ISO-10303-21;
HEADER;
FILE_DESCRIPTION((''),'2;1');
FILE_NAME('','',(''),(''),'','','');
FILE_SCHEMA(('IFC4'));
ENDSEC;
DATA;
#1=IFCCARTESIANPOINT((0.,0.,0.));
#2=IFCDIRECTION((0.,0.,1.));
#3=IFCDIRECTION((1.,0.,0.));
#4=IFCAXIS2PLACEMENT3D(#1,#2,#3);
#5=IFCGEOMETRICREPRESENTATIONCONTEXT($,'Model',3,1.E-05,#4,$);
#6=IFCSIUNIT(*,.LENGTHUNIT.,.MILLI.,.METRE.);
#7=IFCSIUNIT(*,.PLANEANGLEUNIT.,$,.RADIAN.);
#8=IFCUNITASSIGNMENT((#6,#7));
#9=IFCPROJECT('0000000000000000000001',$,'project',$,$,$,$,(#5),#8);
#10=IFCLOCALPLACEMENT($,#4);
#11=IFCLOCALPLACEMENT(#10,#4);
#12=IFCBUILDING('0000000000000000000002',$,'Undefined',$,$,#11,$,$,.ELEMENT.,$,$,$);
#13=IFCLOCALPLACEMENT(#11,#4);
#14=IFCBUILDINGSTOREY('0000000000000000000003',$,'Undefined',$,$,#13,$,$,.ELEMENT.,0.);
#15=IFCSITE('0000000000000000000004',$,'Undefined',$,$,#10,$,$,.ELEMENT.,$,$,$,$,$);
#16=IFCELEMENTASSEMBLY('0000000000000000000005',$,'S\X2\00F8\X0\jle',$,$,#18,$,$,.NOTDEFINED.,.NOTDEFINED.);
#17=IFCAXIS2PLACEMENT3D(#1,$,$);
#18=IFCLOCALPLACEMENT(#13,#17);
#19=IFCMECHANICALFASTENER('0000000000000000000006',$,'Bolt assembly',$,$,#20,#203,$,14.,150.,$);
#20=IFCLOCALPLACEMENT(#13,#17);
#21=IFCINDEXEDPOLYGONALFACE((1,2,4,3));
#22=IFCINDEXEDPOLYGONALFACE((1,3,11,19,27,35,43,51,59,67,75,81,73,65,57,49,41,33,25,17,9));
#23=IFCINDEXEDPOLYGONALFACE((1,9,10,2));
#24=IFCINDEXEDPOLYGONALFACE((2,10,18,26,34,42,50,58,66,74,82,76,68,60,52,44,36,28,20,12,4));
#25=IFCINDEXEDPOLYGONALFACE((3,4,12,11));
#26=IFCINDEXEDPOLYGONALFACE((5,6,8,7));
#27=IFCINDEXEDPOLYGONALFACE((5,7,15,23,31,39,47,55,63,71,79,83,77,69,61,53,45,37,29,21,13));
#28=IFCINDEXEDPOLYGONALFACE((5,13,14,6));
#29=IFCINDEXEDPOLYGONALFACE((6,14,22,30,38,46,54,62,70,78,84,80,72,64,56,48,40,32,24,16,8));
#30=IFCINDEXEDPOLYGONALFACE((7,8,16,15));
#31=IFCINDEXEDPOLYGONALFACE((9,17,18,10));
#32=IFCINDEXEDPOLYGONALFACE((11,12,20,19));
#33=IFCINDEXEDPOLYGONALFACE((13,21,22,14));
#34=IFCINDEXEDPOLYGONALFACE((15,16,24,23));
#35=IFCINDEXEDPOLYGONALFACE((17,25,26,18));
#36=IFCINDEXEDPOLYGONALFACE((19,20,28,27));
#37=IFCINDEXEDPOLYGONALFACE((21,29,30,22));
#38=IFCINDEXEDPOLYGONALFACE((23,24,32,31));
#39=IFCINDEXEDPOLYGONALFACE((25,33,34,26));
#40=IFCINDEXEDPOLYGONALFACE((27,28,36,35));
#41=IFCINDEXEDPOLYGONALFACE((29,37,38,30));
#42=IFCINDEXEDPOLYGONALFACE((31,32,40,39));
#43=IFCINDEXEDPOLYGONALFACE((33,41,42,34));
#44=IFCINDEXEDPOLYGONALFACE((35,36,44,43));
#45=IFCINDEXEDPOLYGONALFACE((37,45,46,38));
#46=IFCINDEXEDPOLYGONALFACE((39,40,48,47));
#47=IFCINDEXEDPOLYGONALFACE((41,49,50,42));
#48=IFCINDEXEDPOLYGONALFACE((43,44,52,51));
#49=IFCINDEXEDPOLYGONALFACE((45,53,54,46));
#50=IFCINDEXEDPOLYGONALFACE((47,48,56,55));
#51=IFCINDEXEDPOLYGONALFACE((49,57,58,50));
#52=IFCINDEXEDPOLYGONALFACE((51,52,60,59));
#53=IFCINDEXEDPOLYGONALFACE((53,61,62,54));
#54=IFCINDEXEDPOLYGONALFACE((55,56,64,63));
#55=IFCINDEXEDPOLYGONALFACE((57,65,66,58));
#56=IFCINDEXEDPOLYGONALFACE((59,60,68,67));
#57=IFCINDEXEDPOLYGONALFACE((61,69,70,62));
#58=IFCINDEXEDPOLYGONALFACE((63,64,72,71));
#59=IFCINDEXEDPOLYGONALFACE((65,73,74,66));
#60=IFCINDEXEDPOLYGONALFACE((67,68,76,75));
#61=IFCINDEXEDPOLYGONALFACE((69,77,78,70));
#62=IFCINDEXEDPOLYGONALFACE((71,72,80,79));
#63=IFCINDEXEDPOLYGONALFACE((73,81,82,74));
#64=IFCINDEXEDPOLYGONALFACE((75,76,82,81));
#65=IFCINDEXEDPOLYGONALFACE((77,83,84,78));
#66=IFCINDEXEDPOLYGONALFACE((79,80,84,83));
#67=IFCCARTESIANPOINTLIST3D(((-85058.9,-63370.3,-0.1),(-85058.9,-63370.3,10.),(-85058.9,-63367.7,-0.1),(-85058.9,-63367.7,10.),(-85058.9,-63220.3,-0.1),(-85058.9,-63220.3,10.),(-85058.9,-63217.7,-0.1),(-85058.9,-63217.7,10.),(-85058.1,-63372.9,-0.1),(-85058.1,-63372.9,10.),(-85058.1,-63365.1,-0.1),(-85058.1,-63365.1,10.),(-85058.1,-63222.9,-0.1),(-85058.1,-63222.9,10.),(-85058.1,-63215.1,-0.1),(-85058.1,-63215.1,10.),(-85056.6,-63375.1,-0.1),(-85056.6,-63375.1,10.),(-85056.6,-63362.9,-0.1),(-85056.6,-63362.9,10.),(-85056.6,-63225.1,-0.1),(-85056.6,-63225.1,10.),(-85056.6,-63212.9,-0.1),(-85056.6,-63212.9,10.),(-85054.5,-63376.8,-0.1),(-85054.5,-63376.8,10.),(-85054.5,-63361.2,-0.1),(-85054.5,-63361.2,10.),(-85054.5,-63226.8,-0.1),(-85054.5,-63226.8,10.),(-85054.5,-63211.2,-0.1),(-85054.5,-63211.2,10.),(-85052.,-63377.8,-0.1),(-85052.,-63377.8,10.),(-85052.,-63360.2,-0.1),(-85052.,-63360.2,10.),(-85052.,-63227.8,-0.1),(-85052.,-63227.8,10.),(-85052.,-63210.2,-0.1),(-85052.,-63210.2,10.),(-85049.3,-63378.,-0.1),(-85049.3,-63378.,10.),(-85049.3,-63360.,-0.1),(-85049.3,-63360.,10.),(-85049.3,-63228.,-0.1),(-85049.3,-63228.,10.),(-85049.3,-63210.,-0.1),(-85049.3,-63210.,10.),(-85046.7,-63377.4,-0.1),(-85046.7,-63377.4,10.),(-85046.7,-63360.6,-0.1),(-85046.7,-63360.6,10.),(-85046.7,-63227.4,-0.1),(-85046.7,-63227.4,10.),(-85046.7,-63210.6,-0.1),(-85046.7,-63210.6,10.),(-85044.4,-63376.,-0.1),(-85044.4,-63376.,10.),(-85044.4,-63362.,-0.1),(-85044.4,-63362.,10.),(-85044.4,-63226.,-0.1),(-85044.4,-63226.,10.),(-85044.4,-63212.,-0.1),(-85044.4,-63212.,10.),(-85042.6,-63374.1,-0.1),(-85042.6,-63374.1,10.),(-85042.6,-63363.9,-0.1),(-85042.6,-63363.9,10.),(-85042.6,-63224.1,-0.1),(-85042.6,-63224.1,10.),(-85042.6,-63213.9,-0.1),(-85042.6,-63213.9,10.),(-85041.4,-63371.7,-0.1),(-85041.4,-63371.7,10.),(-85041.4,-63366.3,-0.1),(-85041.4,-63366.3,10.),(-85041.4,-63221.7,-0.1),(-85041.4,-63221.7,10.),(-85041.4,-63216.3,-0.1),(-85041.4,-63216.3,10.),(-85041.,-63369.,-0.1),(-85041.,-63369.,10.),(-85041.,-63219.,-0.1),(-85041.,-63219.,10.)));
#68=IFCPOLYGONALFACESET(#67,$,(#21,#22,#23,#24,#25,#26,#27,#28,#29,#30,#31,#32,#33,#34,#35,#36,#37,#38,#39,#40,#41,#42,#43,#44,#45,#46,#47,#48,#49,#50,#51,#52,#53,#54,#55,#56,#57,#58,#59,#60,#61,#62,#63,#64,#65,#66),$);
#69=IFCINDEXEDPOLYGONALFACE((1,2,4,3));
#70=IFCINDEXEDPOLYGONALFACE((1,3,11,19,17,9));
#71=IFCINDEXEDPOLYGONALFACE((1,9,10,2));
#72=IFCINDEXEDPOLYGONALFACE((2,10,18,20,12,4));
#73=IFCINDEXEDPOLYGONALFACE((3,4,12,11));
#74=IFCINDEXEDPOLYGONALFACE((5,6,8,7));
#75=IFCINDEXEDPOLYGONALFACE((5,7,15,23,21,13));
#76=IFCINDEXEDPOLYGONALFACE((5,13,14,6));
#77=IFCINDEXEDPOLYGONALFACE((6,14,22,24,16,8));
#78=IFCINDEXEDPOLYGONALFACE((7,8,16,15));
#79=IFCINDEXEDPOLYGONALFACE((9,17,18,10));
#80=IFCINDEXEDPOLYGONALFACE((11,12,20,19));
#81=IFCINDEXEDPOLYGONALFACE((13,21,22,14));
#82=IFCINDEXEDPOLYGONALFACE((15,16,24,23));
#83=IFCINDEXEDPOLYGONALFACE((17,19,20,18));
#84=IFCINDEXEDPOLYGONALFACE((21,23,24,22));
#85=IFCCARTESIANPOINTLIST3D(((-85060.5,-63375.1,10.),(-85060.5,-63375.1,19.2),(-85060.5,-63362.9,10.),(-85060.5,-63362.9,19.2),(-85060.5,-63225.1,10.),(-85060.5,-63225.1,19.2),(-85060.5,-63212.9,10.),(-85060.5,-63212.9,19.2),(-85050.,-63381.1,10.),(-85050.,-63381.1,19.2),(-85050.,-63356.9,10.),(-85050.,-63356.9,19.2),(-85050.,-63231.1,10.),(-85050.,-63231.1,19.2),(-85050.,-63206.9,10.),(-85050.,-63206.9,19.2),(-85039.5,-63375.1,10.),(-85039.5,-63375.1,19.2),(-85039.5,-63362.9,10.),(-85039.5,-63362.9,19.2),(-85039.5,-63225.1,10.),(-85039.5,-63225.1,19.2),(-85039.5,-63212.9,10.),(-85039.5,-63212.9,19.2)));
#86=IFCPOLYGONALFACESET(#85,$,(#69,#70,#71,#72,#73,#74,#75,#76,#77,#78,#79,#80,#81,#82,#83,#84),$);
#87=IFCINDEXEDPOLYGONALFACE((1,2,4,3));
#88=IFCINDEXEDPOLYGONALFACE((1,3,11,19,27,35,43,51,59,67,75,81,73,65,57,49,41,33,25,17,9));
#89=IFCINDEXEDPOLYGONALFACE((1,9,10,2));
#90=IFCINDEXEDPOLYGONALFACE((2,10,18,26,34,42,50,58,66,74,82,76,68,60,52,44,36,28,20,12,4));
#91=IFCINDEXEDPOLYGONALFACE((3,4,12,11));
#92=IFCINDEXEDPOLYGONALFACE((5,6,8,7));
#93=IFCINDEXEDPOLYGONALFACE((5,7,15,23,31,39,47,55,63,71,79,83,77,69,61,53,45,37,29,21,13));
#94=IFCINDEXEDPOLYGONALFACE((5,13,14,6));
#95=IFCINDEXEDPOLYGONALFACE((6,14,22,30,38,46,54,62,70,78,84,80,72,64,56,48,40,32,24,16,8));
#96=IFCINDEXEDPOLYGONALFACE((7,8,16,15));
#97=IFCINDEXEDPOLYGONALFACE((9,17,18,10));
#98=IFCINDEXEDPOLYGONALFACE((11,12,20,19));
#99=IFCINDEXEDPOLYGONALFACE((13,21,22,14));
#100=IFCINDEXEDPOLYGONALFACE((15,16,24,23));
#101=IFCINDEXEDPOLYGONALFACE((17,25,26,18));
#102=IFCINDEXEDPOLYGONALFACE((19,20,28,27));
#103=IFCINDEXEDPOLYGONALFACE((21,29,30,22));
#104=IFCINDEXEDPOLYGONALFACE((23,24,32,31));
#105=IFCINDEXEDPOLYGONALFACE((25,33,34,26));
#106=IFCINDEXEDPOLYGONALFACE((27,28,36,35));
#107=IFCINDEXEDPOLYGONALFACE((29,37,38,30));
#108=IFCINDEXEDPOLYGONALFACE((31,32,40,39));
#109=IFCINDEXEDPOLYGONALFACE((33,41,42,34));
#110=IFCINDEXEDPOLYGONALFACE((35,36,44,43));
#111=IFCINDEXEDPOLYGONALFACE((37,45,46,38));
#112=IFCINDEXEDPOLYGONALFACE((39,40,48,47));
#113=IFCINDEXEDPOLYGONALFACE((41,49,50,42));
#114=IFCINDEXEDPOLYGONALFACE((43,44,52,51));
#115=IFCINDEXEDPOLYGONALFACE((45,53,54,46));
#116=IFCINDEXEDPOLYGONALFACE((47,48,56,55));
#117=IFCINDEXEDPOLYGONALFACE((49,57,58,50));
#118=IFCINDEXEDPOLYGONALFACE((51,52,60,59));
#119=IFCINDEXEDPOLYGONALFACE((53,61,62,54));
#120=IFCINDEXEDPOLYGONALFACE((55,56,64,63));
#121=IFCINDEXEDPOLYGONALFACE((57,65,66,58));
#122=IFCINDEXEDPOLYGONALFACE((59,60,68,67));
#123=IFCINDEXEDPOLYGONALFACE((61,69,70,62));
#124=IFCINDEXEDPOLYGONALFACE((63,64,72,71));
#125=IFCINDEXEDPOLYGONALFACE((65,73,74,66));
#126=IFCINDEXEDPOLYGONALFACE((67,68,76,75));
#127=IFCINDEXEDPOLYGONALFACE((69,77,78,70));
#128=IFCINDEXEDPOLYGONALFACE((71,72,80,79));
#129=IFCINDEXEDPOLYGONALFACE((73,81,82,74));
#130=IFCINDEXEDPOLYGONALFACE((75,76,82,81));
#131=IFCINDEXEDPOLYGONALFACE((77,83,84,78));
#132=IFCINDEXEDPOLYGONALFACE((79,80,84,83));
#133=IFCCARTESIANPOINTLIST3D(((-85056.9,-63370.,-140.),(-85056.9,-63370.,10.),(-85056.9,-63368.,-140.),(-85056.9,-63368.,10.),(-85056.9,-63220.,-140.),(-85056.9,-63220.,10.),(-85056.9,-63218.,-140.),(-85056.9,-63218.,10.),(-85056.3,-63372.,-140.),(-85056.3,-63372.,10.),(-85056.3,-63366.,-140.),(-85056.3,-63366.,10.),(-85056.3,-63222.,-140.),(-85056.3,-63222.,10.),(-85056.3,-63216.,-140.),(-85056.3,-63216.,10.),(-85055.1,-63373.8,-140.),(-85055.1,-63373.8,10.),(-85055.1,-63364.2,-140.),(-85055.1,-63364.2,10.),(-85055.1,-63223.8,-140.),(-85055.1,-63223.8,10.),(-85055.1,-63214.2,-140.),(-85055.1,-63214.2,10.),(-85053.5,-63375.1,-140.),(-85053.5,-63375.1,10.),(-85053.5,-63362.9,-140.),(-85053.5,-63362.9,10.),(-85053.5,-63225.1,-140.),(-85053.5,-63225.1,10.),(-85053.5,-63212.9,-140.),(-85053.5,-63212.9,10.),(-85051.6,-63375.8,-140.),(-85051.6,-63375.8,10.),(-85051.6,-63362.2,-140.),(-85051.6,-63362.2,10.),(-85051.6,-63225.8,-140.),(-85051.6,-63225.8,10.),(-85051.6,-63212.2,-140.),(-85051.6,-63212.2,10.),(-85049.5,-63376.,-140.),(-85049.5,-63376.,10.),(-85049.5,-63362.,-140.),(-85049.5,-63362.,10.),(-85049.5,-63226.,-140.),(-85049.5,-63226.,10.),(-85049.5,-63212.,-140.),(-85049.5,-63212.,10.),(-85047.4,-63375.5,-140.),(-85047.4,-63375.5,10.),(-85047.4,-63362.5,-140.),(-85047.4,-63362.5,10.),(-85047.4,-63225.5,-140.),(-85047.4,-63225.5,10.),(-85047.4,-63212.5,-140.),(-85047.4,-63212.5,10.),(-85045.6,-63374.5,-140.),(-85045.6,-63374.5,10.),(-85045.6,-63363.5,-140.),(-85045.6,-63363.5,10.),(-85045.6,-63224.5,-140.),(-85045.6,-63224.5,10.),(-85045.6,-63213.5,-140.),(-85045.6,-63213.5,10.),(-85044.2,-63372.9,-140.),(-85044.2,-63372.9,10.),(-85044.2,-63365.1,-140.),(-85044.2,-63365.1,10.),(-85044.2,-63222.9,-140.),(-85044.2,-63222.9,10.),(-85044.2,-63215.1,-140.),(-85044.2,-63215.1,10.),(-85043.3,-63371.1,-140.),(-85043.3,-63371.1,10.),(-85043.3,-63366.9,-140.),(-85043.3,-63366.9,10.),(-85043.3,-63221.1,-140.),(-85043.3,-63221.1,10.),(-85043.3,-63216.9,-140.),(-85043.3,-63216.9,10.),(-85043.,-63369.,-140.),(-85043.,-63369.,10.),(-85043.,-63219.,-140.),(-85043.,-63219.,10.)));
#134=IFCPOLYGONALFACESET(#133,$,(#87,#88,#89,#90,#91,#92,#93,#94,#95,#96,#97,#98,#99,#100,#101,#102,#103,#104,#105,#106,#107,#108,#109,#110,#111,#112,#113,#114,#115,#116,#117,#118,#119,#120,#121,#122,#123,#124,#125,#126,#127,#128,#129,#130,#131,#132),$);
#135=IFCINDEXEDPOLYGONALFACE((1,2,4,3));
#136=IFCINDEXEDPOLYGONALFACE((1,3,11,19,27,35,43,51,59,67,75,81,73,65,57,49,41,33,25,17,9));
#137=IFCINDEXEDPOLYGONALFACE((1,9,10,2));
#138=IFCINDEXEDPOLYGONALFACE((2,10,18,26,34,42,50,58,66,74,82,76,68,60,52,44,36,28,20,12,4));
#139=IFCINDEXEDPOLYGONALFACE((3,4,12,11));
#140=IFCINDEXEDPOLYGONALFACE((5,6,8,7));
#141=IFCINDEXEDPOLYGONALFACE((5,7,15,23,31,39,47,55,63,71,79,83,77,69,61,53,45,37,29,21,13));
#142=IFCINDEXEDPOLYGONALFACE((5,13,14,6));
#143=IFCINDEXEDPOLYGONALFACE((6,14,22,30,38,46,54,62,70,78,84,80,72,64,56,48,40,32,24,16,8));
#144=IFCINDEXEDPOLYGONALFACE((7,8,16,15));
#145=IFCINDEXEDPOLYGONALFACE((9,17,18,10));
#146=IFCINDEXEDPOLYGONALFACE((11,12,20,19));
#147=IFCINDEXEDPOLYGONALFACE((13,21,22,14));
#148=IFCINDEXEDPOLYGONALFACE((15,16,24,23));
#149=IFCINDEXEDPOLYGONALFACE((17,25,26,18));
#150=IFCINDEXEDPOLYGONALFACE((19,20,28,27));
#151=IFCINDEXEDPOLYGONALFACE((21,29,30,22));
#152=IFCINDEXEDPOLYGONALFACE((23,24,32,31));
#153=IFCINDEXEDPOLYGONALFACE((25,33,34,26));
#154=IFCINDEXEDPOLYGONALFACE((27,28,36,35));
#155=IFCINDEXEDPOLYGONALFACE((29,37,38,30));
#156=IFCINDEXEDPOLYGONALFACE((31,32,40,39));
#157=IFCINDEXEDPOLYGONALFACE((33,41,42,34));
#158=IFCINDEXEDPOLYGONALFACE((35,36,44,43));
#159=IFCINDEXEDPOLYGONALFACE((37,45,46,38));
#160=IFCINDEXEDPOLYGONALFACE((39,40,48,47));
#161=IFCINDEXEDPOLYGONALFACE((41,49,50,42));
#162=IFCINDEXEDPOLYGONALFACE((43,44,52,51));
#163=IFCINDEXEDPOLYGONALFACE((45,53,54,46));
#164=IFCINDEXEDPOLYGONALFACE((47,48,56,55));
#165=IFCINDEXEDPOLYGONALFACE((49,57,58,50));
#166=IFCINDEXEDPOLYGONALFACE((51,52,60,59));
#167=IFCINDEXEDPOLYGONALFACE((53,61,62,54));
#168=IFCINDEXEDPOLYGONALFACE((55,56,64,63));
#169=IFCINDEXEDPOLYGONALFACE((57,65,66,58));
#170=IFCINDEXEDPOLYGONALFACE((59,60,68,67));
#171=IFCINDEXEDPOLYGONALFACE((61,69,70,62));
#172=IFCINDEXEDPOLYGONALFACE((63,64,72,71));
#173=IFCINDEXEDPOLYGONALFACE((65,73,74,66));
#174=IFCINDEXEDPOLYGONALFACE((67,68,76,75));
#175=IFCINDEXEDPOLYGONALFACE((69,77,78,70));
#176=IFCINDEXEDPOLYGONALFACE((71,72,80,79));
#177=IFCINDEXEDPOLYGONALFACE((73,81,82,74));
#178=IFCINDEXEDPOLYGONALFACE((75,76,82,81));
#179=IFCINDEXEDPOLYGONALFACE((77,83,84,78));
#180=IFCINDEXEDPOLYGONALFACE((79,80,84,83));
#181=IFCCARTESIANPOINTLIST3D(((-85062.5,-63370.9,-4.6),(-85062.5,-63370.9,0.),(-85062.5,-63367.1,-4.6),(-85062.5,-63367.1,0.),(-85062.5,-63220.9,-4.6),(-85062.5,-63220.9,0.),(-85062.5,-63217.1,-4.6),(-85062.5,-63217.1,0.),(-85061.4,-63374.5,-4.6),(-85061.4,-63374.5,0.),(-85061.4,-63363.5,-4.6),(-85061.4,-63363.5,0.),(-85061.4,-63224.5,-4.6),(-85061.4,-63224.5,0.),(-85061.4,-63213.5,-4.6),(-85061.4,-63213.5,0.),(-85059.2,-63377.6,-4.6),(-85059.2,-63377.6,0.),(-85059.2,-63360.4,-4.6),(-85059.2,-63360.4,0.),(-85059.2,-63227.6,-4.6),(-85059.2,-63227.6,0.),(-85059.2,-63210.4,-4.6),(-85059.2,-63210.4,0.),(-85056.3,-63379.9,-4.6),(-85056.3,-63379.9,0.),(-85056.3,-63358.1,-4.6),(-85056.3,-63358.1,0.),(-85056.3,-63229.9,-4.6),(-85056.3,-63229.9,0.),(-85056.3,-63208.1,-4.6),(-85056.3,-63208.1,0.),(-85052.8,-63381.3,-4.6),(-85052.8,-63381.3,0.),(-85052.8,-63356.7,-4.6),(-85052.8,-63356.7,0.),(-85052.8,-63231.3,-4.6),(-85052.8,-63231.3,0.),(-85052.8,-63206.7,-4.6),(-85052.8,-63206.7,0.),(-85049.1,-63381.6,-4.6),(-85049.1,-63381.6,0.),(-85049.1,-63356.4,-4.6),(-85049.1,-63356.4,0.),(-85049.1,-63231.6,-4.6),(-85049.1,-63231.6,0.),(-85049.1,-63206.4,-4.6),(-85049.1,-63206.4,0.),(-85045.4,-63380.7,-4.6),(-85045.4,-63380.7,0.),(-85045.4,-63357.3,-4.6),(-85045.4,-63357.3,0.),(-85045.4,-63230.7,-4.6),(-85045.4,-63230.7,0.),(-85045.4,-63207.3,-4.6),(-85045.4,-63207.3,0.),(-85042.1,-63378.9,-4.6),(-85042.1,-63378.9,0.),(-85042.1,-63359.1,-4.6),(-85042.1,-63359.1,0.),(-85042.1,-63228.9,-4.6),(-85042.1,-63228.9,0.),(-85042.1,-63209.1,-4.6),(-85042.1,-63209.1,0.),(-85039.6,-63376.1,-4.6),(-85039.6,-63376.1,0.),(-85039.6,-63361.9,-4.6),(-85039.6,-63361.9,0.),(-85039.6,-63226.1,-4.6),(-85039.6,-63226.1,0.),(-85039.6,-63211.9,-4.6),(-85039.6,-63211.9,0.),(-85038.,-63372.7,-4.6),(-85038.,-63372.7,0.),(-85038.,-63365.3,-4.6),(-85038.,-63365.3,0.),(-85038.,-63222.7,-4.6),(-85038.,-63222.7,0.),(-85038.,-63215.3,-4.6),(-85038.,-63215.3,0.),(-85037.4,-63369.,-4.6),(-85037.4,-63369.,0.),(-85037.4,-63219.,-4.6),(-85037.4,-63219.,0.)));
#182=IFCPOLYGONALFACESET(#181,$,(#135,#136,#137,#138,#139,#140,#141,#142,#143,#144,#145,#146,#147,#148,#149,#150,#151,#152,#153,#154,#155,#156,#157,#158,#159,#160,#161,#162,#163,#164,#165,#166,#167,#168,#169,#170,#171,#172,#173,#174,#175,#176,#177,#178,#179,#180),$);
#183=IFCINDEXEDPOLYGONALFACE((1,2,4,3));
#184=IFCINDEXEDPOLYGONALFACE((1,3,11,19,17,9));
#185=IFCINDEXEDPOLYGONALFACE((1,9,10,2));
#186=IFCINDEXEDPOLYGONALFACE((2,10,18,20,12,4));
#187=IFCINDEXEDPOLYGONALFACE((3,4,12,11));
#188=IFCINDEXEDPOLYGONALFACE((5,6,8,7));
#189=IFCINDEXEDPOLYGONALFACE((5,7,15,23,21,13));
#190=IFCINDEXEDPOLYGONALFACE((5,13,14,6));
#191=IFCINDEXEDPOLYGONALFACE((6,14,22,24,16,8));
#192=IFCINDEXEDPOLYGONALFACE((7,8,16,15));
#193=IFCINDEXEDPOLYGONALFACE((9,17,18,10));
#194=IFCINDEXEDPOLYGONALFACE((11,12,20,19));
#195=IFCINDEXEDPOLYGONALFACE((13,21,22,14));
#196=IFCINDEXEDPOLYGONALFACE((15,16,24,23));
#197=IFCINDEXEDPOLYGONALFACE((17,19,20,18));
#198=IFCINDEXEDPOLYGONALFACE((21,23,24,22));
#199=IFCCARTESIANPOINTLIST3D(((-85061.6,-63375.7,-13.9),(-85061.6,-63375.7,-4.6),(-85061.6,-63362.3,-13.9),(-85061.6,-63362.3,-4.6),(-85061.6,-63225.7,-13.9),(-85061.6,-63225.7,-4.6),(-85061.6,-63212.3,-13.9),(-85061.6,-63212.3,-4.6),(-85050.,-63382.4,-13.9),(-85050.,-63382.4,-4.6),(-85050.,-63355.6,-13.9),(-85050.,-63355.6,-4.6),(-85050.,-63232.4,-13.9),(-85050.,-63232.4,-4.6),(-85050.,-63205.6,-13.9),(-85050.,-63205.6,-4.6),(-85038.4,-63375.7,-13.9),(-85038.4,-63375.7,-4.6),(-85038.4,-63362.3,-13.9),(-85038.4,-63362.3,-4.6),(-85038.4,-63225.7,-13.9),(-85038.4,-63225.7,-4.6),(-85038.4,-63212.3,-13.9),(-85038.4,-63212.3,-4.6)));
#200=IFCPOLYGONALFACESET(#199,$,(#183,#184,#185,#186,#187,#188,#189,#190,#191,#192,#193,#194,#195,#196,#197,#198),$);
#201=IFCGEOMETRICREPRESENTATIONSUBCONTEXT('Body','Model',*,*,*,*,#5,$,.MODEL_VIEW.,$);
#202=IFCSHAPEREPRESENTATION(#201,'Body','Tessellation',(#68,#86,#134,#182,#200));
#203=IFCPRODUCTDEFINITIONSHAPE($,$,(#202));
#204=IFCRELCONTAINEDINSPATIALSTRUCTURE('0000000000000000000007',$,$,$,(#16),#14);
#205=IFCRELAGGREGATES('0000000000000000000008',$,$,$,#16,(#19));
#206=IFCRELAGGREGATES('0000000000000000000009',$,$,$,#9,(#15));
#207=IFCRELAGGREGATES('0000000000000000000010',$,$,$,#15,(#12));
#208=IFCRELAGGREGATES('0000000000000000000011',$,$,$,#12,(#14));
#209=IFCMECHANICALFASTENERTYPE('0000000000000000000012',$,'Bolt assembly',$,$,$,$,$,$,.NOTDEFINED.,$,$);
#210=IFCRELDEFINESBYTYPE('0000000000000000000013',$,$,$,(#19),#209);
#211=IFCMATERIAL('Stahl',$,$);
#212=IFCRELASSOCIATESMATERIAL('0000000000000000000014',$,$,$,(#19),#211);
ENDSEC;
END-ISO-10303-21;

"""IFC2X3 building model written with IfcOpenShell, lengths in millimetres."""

from ifc_helpers import new_model, si_unit, frame, origin_with_axes, origin_2d_with_axis, place, context, subcontext, project, spatial, polyline, circle, outline, extrude, source, transform, mapped, material, type_object, element, aggregate, save


model = new_model("IFC2X3")

# Units and contexts
model_context = context("Model", 3, precision=1e-05, world=origin_with_axes())
body_context = subcontext(model_context, "Body", "Model", "MODEL_VIEW")
ifc_project = project(units=[si_unit("LENGTHUNIT", "METRE", prefix="MILLI"), si_unit("PLANEANGLEUNIT", "RADIAN")], contexts=[model_context])

# Site, building, storey
site_placement = place(None, origin_with_axes())
site = spatial("IfcSite", under=ifc_project, at=site_placement, Name="Undefined", CompositionType="ELEMENT")
building_placement = place(site_placement, origin_with_axes())
building = spatial("IfcBuilding", under=site, at=building_placement, Name="Undefined", CompositionType="ELEMENT")
storey_placement = place(building_placement, origin_with_axes())
storey = spatial("IfcBuildingStorey", under=building, at=storey_placement, Name="Undefined", CompositionType="ELEMENT", Elevation=0.0)

# Shared definitions
mechanical_fastener_type = type_object("IfcMechanicalFastenerType", Name="Bolt assembly")

# Element assembly
assembly_1_placement = place(storey_placement, origin_with_axes())
assembly_1 = element("IfcElementAssembly", 1, at=assembly_1_placement, inside=storey, Name="Søjle", AssemblyPlace="NOTDEFINED", PredefinedType="NOTDEFINED")

# Mechanical fastener
ifc_material_1 = material(Name="Stahl")
shared_shape_1 = source(origin_with_axes(), body_context, "Body", "SweptSolid", [
    extrude(circle(Radius=9.0, at=origin_2d_with_axis()), frame((0.0, 0.0, 0.0), z_axis=(0.0, 1.0, 0.0), x_axis=(1.0, 0.0, 0.0)), (0.0, 0.0, 1.0), 10.1),
    extrude(outline(polyline([(10.5, -6.1), (10.5, 6.1), (0.0, 12.1), (-10.5, 6.1), (-10.5, -6.1), (0.0, -12.1), (10.5, -6.1)])), frame((0.0, -9.2, 0.0), z_axis=(0.0, 1.0, 0.0), x_axis=(1.0, 0.0, 0.0)), (0.0, 0.0, 1.0), 9.2),
    extrude(circle(Radius=7.0, at=origin_2d_with_axis()), frame((0.0, 0.0, 0.0), z_axis=(0.0, 1.0, 0.0), x_axis=(1.0, 0.0, 0.0)), (0.0, 0.0, 1.0), 150.0),
    extrude(circle(Radius=12.6, at=origin_2d_with_axis()), frame((0.0, 10.0, 0.0), z_axis=(0.0, 1.0, 0.0), x_axis=(1.0, 0.0, 0.0)), (0.0, 0.0, 1.0), 4.6),
    extrude(outline(polyline([(11.6, -6.7), (11.6, 6.7), (0.0, 13.4), (-11.6, 6.7), (-11.6, -6.7), (0.0, -13.4), (11.6, -6.7)])), frame((0.0, 14.6, 0.0), z_axis=(0.0, 1.0, 0.0), x_axis=(1.0, 0.0, 0.0)), (0.0, 0.0, 1.0), 9.2),
])
mechanical_fastener_1_placement = place(assembly_1_placement, frame((-85050.0, -63294.0, 10.0), z_axis=(0.0, 1.0, 0.0), x_axis=(1.0, 0.0, 0.0)))
mechanical_fastener_1 = element("IfcMechanicalFastener", 2, at=mechanical_fastener_1_placement, type_object=mechanical_fastener_type, material=ifc_material_1, Name="Bolt assembly", NominalDiameter=14.0, NominalLength=150.0, context=body_context, shape_type="MappedRepresentation", body=[
    mapped(shared_shape_1, transform((0.0, 0.0, -75.0))),
    mapped(shared_shape_1, transform((0.0, 0.0, 75.0))),
])
aggregate(assembly_1, [mechanical_fastener_1])

save(model, "model.ifc")
